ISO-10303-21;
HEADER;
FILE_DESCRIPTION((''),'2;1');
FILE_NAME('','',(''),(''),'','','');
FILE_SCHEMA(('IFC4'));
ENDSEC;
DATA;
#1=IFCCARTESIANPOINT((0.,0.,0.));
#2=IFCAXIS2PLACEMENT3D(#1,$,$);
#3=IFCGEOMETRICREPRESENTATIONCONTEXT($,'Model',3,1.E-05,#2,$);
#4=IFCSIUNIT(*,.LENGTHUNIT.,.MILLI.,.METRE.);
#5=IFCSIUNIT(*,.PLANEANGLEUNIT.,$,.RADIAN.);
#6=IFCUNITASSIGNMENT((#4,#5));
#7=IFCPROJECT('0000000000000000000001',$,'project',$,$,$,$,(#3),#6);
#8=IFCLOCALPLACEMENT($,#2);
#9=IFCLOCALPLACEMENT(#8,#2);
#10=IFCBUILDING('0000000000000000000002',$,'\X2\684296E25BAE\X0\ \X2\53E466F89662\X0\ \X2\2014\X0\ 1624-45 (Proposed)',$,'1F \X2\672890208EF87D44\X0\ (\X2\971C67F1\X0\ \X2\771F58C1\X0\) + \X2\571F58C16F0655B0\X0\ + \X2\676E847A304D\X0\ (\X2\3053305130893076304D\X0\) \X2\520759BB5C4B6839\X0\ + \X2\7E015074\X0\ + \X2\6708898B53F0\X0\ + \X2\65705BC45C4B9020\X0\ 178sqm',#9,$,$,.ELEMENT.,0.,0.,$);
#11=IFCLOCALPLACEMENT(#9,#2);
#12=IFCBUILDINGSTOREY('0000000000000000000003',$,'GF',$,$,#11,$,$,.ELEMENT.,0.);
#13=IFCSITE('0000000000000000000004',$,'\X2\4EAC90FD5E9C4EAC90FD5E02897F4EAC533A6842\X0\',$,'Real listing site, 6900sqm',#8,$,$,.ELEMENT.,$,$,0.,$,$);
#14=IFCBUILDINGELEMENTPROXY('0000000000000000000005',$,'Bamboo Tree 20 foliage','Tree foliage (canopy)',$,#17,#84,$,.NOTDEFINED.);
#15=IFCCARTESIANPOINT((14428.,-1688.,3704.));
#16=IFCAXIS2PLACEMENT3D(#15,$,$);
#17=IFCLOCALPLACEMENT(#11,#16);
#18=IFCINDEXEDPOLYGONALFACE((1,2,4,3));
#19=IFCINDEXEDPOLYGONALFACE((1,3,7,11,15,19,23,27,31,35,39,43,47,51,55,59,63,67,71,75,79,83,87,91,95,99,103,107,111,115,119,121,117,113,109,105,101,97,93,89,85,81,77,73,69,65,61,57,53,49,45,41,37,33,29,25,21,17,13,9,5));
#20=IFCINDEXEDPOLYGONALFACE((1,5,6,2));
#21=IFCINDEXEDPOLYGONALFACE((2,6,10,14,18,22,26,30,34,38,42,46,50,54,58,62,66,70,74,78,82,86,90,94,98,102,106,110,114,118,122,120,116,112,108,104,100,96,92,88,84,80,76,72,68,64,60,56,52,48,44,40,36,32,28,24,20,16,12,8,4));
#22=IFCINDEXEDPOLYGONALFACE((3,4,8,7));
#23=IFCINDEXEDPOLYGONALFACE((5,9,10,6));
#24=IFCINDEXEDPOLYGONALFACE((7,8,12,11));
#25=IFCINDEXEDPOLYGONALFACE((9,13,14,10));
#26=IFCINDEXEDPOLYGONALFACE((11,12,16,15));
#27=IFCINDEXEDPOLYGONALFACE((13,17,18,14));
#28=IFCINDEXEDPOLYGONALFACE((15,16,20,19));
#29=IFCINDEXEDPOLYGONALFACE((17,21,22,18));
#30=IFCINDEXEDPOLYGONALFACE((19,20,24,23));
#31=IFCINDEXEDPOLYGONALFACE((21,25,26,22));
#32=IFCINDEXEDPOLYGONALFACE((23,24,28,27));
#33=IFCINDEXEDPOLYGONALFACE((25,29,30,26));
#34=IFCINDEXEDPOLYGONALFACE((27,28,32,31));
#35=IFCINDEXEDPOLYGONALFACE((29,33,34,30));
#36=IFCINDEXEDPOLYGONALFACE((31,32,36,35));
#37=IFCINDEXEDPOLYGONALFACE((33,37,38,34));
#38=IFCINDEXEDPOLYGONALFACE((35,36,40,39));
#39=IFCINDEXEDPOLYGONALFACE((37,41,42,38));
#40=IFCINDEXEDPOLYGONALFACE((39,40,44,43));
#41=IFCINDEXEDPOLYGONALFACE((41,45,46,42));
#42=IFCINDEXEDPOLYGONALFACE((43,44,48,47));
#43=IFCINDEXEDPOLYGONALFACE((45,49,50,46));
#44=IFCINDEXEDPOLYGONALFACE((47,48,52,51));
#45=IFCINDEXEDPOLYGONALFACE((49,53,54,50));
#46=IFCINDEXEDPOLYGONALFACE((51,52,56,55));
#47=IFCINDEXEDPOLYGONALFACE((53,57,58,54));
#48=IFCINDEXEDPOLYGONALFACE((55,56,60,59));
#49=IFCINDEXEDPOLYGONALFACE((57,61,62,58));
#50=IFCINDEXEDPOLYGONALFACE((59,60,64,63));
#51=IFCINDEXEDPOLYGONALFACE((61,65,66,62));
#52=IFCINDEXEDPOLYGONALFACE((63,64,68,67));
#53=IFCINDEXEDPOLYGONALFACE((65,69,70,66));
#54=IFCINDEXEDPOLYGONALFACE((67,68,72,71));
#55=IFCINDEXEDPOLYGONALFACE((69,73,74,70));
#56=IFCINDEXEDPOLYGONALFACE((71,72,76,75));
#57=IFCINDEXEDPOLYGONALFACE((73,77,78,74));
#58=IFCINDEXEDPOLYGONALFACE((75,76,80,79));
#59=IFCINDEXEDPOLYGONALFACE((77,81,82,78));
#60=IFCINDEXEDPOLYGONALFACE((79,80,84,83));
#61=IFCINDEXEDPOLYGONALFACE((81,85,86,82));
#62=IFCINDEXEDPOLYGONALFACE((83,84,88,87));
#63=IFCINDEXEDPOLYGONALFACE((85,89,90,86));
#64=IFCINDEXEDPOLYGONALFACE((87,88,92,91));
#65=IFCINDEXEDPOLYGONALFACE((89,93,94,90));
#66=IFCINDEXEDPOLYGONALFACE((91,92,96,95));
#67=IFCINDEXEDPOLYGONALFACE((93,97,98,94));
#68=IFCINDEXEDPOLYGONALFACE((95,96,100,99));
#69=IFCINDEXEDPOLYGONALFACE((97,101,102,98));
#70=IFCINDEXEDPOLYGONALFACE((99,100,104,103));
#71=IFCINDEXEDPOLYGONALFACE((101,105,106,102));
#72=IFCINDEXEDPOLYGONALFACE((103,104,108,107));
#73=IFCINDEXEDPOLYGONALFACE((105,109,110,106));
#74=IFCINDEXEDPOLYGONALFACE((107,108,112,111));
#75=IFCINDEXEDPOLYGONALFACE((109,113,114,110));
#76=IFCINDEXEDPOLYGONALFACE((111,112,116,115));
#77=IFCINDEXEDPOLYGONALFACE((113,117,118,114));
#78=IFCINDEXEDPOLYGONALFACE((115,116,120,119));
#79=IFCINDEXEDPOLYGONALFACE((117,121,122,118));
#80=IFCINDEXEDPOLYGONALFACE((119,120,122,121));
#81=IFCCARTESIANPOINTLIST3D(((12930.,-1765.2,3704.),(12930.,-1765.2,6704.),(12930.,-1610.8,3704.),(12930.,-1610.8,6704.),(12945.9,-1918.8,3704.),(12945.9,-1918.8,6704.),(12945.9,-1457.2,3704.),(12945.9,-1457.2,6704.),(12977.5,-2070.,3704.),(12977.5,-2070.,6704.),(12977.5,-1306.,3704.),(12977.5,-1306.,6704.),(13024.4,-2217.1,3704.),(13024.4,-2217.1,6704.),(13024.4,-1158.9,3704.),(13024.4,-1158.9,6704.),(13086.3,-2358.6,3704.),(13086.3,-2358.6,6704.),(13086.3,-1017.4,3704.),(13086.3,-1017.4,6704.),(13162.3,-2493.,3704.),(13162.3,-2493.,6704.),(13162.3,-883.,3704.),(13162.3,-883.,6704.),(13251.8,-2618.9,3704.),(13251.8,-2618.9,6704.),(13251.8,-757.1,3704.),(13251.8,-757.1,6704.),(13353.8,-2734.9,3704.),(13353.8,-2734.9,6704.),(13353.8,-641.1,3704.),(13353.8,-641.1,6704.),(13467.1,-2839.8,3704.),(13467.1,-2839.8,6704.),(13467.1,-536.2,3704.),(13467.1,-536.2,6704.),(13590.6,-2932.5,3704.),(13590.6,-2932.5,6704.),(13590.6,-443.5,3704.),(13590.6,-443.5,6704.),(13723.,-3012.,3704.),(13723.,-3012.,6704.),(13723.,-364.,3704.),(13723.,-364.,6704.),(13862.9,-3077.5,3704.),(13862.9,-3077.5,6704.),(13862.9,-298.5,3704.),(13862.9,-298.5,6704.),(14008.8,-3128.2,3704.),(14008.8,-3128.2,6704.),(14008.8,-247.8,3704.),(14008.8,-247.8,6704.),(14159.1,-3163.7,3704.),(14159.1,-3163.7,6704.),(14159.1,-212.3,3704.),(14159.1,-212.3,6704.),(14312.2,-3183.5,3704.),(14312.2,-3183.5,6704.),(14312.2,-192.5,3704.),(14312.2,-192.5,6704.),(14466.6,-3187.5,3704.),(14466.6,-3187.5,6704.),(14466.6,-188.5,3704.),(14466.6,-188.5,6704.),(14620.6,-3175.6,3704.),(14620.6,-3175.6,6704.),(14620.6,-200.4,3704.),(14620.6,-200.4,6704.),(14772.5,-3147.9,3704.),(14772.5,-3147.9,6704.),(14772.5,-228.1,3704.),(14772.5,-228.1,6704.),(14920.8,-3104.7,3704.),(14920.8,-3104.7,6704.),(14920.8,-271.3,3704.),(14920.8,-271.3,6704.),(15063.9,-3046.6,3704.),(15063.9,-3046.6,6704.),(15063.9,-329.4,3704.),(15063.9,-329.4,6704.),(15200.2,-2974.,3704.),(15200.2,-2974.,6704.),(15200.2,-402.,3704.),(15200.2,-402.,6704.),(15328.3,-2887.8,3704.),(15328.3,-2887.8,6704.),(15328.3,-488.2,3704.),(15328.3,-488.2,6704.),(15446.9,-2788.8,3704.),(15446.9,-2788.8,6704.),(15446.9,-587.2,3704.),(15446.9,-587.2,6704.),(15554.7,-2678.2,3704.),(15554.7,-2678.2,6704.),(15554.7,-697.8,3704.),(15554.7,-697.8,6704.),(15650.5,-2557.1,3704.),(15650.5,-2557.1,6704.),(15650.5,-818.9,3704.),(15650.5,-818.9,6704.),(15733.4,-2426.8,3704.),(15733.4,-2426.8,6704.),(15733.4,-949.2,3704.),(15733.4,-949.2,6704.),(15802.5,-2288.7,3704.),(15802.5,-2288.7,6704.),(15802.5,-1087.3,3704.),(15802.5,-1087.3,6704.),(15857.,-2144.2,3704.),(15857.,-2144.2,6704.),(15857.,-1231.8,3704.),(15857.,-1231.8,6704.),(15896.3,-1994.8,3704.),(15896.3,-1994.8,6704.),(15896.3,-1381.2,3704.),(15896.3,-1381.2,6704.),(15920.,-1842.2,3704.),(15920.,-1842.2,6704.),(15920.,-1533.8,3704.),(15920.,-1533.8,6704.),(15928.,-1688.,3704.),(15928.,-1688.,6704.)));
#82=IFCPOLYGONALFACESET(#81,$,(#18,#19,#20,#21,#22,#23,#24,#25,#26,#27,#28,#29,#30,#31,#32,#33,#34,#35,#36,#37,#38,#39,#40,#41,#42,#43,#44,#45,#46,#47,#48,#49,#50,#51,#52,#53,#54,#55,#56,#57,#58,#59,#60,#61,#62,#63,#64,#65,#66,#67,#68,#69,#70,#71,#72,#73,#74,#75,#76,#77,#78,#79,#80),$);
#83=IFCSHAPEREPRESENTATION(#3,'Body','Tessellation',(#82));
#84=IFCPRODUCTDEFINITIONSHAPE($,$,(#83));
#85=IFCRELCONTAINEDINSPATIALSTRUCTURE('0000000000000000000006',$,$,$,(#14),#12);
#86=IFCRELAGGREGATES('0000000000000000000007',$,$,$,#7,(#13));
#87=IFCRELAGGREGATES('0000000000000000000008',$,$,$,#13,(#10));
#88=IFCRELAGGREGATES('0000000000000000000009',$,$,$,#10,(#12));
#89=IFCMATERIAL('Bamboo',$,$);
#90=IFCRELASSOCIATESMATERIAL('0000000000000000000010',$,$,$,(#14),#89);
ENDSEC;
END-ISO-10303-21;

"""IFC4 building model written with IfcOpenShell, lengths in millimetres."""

from ifc_helpers import new_model, si_unit, frame, origin, origin_2d, place, context, project, spatial, circle, extrude, material, element, save


model = new_model("IFC4")

# Units and contexts
model_context = context("Model", 3, precision=1e-05, world=origin())
ifc_project = project(units=[si_unit("LENGTHUNIT", "METRE", prefix="MILLI"), si_unit("PLANEANGLEUNIT", "RADIAN")], contexts=[model_context])

# Site, building, storey
site_placement = place(None, origin())
site = spatial("IfcSite", under=ifc_project, at=site_placement, Name="京都府京都市西京区桂", ObjectType="Real listing site, 6900sqm", CompositionType="ELEMENT", RefElevation=0.0)
building_placement = place(site_placement, origin())
building = spatial("IfcBuilding", under=site, at=building_placement, Name="桂離宮 古書院 — 1624-45 (Proposed)", ObjectType="1F 木造軸組 (霜柱 真壁) + 土壁漆喰 + 杮葺き (こけらぶき) 切妻屋根 + 縁側 + 月見台 + 数寄屋造 178sqm", CompositionType="ELEMENT", ElevationOfRefHeight=0.0, ElevationOfTerrain=0.0)
storey_placement = place(building_placement, origin())
storey = spatial("IfcBuildingStorey", under=building, at=storey_placement, Name="GF", CompositionType="ELEMENT", Elevation=0.0)

# Building element proxy
ifc_material_1 = material(Name="Bamboo")
proxy_1_placement = place(storey_placement, frame((14428.0, -1688.0, 3704.0)))
element("IfcBuildingElementProxy", 1, at=proxy_1_placement, inside=storey, material=ifc_material_1, Name="Bamboo Tree 20 foliage", Description="Tree foliage (canopy)", PredefinedType="NOTDEFINED", context=model_context, shape_type="SweptSolid", body=[
    extrude(circle(Radius=1500.0, at=origin_2d()), frame((14428.0, -1688.0, 3704.0)), (0.0, 0.0, 1.0), 3000.0),
])

save(model, "model.ifc")
